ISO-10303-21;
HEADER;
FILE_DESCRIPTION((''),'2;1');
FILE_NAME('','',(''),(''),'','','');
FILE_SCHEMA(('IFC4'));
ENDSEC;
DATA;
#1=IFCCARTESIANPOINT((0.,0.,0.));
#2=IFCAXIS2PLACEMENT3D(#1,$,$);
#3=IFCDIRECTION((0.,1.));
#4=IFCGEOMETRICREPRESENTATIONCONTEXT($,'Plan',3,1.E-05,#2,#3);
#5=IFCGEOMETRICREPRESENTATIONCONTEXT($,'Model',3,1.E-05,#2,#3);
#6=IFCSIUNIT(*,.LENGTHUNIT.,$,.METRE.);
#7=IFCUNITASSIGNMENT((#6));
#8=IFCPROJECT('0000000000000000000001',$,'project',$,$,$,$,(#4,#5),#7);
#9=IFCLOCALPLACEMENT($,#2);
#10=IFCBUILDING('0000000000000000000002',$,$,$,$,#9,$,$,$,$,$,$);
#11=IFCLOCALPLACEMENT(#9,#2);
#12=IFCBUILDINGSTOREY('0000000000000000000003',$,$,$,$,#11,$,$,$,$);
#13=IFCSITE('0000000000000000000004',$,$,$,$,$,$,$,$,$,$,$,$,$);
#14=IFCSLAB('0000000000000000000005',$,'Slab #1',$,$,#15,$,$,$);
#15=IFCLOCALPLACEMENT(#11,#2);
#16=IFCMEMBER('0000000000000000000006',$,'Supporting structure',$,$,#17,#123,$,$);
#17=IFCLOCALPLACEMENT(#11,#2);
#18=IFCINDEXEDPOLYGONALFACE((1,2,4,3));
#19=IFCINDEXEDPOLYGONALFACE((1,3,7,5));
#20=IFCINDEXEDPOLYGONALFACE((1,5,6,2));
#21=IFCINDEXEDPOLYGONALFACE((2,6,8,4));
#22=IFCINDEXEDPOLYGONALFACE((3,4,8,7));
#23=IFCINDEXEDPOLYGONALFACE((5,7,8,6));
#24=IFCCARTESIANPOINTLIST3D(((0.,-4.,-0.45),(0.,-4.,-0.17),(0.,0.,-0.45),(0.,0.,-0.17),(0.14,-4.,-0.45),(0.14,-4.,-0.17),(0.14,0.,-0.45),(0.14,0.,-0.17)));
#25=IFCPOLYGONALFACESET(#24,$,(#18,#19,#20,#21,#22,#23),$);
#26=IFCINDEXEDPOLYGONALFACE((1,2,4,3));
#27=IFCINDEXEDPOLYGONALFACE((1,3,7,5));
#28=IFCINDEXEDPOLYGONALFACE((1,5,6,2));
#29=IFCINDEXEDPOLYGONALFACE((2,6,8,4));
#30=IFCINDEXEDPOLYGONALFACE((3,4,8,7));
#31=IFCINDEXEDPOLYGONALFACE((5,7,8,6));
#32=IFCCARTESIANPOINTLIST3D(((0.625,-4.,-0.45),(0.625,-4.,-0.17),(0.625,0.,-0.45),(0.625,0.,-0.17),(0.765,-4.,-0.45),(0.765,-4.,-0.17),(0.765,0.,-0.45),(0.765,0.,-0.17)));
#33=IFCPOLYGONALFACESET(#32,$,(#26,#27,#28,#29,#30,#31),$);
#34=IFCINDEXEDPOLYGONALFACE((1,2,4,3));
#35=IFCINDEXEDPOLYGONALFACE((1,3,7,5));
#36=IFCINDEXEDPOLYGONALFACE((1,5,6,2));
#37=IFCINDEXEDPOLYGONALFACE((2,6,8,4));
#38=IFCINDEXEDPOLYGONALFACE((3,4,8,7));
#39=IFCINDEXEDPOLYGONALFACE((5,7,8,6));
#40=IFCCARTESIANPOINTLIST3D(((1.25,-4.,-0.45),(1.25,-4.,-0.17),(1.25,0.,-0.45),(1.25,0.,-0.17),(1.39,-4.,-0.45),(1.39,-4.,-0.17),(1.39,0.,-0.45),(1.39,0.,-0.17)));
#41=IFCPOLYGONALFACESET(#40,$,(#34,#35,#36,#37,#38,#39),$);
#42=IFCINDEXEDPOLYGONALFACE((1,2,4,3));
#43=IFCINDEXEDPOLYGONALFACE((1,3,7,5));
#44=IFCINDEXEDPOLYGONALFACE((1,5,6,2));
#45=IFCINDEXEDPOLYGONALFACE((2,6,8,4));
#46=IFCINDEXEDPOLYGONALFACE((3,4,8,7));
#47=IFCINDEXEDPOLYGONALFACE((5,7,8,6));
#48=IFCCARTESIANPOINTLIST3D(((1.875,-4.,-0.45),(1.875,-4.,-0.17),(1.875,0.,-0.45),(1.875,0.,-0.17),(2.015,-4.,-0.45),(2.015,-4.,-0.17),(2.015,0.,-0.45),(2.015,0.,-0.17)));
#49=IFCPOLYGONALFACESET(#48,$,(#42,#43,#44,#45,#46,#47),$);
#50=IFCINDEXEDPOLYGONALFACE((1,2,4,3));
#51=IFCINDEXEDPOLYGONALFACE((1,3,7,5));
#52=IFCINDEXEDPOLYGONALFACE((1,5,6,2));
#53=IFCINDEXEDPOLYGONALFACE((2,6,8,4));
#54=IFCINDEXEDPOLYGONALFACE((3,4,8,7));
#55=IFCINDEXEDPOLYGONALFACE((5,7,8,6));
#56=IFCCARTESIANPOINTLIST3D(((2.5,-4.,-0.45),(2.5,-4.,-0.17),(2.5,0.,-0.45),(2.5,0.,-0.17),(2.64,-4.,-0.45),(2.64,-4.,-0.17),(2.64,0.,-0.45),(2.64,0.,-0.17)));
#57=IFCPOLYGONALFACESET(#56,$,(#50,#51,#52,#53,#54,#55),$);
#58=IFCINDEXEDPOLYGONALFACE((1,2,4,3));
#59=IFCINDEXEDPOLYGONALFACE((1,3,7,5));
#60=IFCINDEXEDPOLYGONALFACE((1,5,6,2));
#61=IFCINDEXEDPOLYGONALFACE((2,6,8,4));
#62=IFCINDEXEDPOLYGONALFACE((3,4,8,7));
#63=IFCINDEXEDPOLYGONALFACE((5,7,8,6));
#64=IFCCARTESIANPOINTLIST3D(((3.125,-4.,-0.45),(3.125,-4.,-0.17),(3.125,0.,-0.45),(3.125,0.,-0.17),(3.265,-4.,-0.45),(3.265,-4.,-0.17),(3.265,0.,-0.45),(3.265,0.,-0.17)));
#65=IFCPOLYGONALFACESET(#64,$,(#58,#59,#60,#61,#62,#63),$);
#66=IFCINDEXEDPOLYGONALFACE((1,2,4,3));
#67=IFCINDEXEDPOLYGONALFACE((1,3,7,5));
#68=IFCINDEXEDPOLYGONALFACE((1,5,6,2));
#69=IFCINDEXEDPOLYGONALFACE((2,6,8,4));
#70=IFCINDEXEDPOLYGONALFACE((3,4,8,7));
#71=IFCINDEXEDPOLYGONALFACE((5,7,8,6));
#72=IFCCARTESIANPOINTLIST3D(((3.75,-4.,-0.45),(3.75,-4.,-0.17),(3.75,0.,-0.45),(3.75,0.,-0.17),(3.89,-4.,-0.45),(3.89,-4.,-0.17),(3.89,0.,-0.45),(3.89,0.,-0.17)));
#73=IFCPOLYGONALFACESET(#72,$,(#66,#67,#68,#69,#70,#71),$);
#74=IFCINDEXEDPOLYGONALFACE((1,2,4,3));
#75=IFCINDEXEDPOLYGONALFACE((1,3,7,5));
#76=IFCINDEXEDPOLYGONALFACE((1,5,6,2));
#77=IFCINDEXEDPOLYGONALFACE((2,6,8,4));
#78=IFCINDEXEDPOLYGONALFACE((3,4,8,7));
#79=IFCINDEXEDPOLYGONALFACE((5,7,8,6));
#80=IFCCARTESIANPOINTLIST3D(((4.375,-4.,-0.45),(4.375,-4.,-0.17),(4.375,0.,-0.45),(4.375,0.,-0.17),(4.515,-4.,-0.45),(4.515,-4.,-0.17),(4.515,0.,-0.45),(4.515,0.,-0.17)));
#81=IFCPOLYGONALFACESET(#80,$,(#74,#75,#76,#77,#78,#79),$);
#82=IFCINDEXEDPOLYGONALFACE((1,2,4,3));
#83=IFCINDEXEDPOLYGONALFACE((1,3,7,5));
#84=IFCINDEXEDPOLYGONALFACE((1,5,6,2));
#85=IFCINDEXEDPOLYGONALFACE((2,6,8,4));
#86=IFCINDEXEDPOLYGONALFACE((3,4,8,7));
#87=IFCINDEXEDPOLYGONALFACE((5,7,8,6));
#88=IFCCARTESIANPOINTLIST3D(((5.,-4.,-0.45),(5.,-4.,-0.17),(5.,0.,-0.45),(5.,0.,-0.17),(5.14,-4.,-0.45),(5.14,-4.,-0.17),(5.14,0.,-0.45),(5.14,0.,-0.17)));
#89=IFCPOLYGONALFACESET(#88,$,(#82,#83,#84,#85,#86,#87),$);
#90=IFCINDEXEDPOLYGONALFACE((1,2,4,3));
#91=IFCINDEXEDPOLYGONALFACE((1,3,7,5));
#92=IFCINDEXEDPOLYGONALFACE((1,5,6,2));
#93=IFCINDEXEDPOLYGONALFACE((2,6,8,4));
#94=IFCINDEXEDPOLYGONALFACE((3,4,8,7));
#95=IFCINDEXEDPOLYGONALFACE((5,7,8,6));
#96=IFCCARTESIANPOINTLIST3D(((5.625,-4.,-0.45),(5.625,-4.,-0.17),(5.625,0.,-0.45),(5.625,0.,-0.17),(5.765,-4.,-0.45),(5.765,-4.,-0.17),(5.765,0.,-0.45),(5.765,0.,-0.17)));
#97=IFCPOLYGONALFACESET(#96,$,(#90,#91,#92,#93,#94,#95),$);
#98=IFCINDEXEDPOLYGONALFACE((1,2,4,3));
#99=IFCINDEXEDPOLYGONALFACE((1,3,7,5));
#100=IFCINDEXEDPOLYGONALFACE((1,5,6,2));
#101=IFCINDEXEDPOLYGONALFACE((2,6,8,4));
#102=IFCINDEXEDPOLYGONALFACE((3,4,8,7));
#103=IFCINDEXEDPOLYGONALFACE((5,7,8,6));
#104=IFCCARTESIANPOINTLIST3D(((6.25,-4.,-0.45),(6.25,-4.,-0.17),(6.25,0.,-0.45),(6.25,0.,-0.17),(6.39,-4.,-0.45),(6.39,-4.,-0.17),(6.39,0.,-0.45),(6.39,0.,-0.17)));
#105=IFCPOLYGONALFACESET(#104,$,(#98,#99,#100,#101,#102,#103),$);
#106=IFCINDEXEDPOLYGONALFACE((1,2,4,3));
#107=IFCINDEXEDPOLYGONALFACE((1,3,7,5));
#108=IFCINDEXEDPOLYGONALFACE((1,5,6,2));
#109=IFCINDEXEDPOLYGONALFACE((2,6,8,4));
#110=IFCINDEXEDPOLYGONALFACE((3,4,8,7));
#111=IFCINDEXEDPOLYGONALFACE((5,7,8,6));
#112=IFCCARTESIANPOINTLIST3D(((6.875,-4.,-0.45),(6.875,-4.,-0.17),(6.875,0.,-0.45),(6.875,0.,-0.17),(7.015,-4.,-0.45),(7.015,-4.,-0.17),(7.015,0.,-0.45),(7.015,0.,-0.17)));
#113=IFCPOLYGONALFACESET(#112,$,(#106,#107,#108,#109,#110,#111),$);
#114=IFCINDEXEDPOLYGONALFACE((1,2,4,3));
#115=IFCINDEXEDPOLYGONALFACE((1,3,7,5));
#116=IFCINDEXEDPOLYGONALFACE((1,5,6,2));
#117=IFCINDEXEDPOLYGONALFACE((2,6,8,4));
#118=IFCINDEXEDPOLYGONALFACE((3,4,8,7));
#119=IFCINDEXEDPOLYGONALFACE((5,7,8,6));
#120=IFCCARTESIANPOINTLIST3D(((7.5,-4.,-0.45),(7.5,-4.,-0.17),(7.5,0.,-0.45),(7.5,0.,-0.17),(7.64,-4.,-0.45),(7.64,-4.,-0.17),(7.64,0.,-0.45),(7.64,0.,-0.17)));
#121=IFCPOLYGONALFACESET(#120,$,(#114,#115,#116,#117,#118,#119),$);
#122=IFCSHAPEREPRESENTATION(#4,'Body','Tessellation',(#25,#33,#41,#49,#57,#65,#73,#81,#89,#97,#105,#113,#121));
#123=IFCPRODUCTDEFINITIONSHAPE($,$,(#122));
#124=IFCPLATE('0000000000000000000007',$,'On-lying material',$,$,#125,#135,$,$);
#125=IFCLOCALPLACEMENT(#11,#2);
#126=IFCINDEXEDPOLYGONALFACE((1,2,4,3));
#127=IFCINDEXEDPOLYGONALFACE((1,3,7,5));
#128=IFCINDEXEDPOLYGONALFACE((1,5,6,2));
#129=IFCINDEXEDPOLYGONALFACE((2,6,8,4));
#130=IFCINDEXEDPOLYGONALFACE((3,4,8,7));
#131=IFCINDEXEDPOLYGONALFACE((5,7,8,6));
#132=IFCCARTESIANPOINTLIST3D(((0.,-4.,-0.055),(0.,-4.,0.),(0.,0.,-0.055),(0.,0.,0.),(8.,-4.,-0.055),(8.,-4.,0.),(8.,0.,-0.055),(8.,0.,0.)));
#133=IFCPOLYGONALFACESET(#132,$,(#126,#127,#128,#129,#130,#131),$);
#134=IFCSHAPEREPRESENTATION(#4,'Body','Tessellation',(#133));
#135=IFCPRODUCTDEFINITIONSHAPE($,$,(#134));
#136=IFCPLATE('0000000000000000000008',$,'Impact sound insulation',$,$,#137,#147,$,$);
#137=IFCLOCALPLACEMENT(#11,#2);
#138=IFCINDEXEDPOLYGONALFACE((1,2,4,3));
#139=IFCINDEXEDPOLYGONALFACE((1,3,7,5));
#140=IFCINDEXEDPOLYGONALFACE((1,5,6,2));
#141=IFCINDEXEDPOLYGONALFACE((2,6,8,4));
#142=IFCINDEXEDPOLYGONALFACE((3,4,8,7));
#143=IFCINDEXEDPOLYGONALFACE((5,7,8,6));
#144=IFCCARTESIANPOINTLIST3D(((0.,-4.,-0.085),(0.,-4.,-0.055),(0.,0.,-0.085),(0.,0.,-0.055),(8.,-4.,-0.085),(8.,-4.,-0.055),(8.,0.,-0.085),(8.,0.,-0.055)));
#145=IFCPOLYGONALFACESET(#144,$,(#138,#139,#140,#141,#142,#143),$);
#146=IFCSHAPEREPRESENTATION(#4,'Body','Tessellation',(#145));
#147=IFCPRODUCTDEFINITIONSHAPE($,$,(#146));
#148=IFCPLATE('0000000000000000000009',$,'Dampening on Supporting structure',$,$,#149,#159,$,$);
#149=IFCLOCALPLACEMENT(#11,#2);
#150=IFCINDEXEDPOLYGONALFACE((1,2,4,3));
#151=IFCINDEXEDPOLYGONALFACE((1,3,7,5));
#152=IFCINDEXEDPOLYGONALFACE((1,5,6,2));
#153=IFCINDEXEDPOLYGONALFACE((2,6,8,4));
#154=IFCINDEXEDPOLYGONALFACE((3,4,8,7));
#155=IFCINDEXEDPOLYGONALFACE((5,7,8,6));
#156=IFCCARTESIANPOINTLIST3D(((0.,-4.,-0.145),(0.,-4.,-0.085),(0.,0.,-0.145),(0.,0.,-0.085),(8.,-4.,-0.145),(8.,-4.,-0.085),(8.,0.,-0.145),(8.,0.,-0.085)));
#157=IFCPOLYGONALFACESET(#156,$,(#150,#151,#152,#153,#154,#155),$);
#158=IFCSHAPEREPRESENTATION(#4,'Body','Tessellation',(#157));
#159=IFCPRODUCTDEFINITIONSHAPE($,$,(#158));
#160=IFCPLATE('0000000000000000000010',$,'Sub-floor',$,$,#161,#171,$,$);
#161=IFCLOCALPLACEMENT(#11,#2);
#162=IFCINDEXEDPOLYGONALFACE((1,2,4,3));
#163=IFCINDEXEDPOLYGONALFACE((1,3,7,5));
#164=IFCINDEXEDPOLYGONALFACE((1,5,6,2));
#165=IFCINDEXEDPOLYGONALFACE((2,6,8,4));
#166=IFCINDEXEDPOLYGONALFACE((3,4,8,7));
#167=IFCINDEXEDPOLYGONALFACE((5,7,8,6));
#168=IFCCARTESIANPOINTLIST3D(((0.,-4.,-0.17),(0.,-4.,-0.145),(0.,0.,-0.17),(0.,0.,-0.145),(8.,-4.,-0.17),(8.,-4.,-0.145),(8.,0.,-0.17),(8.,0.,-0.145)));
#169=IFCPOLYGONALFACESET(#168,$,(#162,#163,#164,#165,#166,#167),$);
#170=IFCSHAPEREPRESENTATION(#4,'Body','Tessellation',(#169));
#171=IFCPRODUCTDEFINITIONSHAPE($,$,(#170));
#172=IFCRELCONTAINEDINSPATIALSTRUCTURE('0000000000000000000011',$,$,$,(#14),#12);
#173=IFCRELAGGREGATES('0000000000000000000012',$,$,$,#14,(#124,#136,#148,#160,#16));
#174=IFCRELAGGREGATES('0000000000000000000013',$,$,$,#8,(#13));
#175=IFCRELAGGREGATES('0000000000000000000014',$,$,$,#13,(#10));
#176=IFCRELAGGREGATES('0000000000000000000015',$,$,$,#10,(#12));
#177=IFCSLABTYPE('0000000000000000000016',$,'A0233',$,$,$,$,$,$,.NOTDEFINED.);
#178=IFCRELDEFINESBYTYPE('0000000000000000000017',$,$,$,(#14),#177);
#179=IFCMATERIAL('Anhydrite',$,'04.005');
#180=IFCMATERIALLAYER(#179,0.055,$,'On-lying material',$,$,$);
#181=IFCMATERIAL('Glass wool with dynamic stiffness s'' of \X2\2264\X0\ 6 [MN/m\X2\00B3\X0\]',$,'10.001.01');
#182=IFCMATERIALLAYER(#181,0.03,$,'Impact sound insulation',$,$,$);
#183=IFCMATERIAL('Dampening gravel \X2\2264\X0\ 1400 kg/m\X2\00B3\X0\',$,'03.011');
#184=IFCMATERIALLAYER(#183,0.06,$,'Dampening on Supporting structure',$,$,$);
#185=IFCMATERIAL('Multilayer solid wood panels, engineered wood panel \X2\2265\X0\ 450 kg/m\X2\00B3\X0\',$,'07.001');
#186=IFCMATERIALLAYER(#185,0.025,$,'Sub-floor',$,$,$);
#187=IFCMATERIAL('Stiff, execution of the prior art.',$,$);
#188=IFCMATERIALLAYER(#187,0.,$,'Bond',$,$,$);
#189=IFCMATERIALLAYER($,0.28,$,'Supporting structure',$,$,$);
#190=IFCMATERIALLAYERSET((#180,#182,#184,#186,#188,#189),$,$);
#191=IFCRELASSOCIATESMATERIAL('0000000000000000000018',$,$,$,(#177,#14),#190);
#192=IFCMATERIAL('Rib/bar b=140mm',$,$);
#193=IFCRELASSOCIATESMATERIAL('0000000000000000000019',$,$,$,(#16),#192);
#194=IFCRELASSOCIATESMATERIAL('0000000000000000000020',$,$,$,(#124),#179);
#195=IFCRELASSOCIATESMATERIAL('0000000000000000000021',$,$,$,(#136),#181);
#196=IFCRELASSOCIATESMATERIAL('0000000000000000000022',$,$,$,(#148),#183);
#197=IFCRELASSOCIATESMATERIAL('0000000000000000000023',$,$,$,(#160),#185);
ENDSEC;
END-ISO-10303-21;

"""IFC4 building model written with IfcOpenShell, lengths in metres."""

from ifc_helpers import new_model, si_unit, direction, frame, frame_2d, origin, origin_with_axes, place, context, project, spatial, rectangle, extrude, material, layer, layer_set, type_object, element, aggregate, save


model = new_model("IFC4")

# Units and contexts
plan_context = context("Plan", 3, precision=1e-05, world=origin(), true_north=direction((0.0, 1.0)))
model_context = context("Model", 3, precision=1e-05, world=origin(), true_north=direction((0.0, 1.0)))
ifc_project = project(units=[si_unit("LENGTHUNIT", "METRE")], contexts=[plan_context, model_context])

# Site, building, storey
site = spatial("IfcSite", under=ifc_project)
building_placement = place(None, origin())
building = spatial("IfcBuilding", under=site, at=building_placement)
storey_placement = place(building_placement, origin())
storey = spatial("IfcBuildingStorey", under=building, at=storey_placement)

# Slab, member, plates
ifc_material_1 = material(Name="Anhydrite", Category="04.005")
ifc_layer_1 = layer(ifc_material_1, 0.055, Name="On-lying material")
ifc_material_2 = material(Name="Glass wool with dynamic stiffness s' of ≤ 6 [MN/m³]", Category="10.001.01")
ifc_layer_2 = layer(ifc_material_2, 0.03, Name="Impact sound insulation")
ifc_material_3 = material(Name="Dampening gravel ≤ 1400 kg/m³", Category="03.011")
ifc_layer_3 = layer(ifc_material_3, 0.06, Name="Dampening on Supporting structure")
ifc_material_4 = material(Name="Multilayer solid wood panels, engineered wood panel ≥ 450 kg/m³", Category="07.001")
ifc_layer_4 = layer(ifc_material_4, 0.025, Name="Sub-floor")
ifc_material_5 = material(Name="Stiff, execution of the prior art.")
ifc_layer_5 = layer(ifc_material_5, 0.0, Name="Bond")
ifc_layer_6 = layer(None, 0.28, Name="Supporting structure")
ifc_layer_set = layer_set([ifc_layer_1, ifc_layer_2, ifc_layer_3, ifc_layer_4, ifc_layer_5, ifc_layer_6])
slab_type = type_object("IfcSlabType", Name="A0233", PredefinedType="NOTDEFINED", material=ifc_layer_set)
slab_placement = place(None, frame((0.0, 0.0, 0.0), z_axis=(0.0, 0.0, -1.0), x_axis=(1.0, 0.0, 0.0)))
slab = element("IfcSlab", 1, at=slab_placement, inside=storey, type_object=slab_type, material=ifc_layer_set, Name="Slab #1")
ifc_material_6 = material(Name="Rib/bar b=140mm")
member_placement = place(slab_placement, origin())
member = element("IfcMember", 2, at=member_placement, material=ifc_material_6, Name="Supporting structure", context=plan_context, shape_type="SweptSolid", body=[
    extrude(rectangle(XDim=0.14, YDim=0.28, at=frame_2d((0.07, 0.14), x_axis=(1.0, 0.0))), frame((0.0, 4.0, 0.17), z_axis=(0.0, -1.0, 0.0), x_axis=(1.0, 0.0, 0.0)), (0.0, 0.0, 1.0), 4.0),
    extrude(rectangle(XDim=0.14, YDim=0.28, at=frame_2d((0.07, 0.14), x_axis=(1.0, 0.0))), frame((0.625, 4.0, 0.17), z_axis=(0.0, -1.0, 0.0), x_axis=(1.0, 0.0, 0.0)), (0.0, 0.0, 1.0), 4.0),
    extrude(rectangle(XDim=0.14, YDim=0.28, at=frame_2d((0.07, 0.14), x_axis=(1.0, 0.0))), frame((1.25, 4.0, 0.17), z_axis=(0.0, -1.0, 0.0), x_axis=(1.0, 0.0, 0.0)), (0.0, 0.0, 1.0), 4.0),
    extrude(rectangle(XDim=0.14, YDim=0.28, at=frame_2d((0.07, 0.14), x_axis=(1.0, 0.0))), frame((1.875, 4.0, 0.17), z_axis=(0.0, -1.0, 0.0), x_axis=(1.0, 0.0, 0.0)), (0.0, 0.0, 1.0), 4.0),
    extrude(rectangle(XDim=0.14, YDim=0.28, at=frame_2d((0.07, 0.14), x_axis=(1.0, 0.0))), frame((2.5, 4.0, 0.17), z_axis=(0.0, -1.0, 0.0), x_axis=(1.0, 0.0, 0.0)), (0.0, 0.0, 1.0), 4.0),
    extrude(rectangle(XDim=0.14, YDim=0.28, at=frame_2d((0.07, 0.14), x_axis=(1.0, 0.0))), frame((3.125, 4.0, 0.17), z_axis=(0.0, -1.0, 0.0), x_axis=(1.0, 0.0, 0.0)), (0.0, 0.0, 1.0), 4.0),
    extrude(rectangle(XDim=0.14, YDim=0.28, at=frame_2d((0.07, 0.14), x_axis=(1.0, 0.0))), frame((3.75, 4.0, 0.17), z_axis=(0.0, -1.0, 0.0), x_axis=(1.0, 0.0, 0.0)), (0.0, 0.0, 1.0), 4.0),
    extrude(rectangle(XDim=0.14, YDim=0.28, at=frame_2d((0.07, 0.14), x_axis=(1.0, 0.0))), frame((4.375, 4.0, 0.17), z_axis=(0.0, -1.0, 0.0), x_axis=(1.0, 0.0, 0.0)), (0.0, 0.0, 1.0), 4.0),
    extrude(rectangle(XDim=0.14, YDim=0.28, at=frame_2d((0.07, 0.14), x_axis=(1.0, 0.0))), frame((5.0, 4.0, 0.17), z_axis=(0.0, -1.0, 0.0), x_axis=(1.0, 0.0, 0.0)), (0.0, 0.0, 1.0), 4.0),
    extrude(rectangle(XDim=0.14, YDim=0.28, at=frame_2d((0.07, 0.14), x_axis=(1.0, 0.0))), frame((5.625, 4.0, 0.17), z_axis=(0.0, -1.0, 0.0), x_axis=(1.0, 0.0, 0.0)), (0.0, 0.0, 1.0), 4.0),
    extrude(rectangle(XDim=0.14, YDim=0.28, at=frame_2d((0.07, 0.14), x_axis=(1.0, 0.0))), frame((6.25, 4.0, 0.17), z_axis=(0.0, -1.0, 0.0), x_axis=(1.0, 0.0, 0.0)), (0.0, 0.0, 1.0), 4.0),
    extrude(rectangle(XDim=0.14, YDim=0.28, at=frame_2d((0.07, 0.14), x_axis=(1.0, 0.0))), frame((6.875, 4.0, 0.17), z_axis=(0.0, -1.0, 0.0), x_axis=(1.0, 0.0, 0.0)), (0.0, 0.0, 1.0), 4.0),
    extrude(rectangle(XDim=0.14, YDim=0.28, at=frame_2d((0.07, 0.14), x_axis=(1.0, 0.0))), frame((7.5, 4.0, 0.17), z_axis=(0.0, -1.0, 0.0), x_axis=(1.0, 0.0, 0.0)), (0.0, 0.0, 1.0), 4.0),
])
plate_1_placement = place(slab_placement, origin())
plate_1 = element("IfcPlate", 3, at=plate_1_placement, material=ifc_material_1, Name="On-lying material", context=plan_context, shape_type="SweptSolid", body=[
    extrude(rectangle(XDim=8.0, YDim=4.0, at=frame_2d((4.0, 2.0), x_axis=(1.0, 0.0))), origin_with_axes(), (0.0, 0.0, 1.0), 0.055),
])
plate_2_placement = place(slab_placement, origin())
plate_2 = element("IfcPlate", 4, at=plate_2_placement, material=ifc_material_2, Name="Impact sound insulation", context=plan_context, shape_type="SweptSolid", body=[
    extrude(rectangle(XDim=8.0, YDim=4.0, at=frame_2d((4.0, 2.0), x_axis=(1.0, 0.0))), frame((0.0, 0.0, 0.055), z_axis=(0.0, 0.0, 1.0), x_axis=(1.0, 0.0, 0.0)), (0.0, 0.0, 1.0), 0.03),
])
plate_3_placement = place(slab_placement, origin())
plate_3 = element("IfcPlate", 5, at=plate_3_placement, material=ifc_material_3, Name="Dampening on Supporting structure", context=plan_context, shape_type="SweptSolid", body=[
    extrude(rectangle(XDim=8.0, YDim=4.0, at=frame_2d((4.0, 2.0), x_axis=(1.0, 0.0))), frame((0.0, 0.0, 0.085), z_axis=(0.0, 0.0, 1.0), x_axis=(1.0, 0.0, 0.0)), (0.0, 0.0, 1.0), 0.06),
])
plate_4_placement = place(slab_placement, origin())
plate_4 = element("IfcPlate", 6, at=plate_4_placement, material=ifc_material_4, Name="Sub-floor", context=plan_context, shape_type="SweptSolid", body=[
    extrude(rectangle(XDim=8.0, YDim=4.0, at=frame_2d((4.0, 2.0), x_axis=(1.0, 0.0))), frame((0.0, 0.0, 0.145), z_axis=(0.0, 0.0, 1.0), x_axis=(1.0, 0.0, 0.0)), (0.0, 0.0, 1.0), 0.025),
])
aggregate(slab, [plate_1, plate_2, plate_3, plate_4, member])

save(model, "model.ifc")
